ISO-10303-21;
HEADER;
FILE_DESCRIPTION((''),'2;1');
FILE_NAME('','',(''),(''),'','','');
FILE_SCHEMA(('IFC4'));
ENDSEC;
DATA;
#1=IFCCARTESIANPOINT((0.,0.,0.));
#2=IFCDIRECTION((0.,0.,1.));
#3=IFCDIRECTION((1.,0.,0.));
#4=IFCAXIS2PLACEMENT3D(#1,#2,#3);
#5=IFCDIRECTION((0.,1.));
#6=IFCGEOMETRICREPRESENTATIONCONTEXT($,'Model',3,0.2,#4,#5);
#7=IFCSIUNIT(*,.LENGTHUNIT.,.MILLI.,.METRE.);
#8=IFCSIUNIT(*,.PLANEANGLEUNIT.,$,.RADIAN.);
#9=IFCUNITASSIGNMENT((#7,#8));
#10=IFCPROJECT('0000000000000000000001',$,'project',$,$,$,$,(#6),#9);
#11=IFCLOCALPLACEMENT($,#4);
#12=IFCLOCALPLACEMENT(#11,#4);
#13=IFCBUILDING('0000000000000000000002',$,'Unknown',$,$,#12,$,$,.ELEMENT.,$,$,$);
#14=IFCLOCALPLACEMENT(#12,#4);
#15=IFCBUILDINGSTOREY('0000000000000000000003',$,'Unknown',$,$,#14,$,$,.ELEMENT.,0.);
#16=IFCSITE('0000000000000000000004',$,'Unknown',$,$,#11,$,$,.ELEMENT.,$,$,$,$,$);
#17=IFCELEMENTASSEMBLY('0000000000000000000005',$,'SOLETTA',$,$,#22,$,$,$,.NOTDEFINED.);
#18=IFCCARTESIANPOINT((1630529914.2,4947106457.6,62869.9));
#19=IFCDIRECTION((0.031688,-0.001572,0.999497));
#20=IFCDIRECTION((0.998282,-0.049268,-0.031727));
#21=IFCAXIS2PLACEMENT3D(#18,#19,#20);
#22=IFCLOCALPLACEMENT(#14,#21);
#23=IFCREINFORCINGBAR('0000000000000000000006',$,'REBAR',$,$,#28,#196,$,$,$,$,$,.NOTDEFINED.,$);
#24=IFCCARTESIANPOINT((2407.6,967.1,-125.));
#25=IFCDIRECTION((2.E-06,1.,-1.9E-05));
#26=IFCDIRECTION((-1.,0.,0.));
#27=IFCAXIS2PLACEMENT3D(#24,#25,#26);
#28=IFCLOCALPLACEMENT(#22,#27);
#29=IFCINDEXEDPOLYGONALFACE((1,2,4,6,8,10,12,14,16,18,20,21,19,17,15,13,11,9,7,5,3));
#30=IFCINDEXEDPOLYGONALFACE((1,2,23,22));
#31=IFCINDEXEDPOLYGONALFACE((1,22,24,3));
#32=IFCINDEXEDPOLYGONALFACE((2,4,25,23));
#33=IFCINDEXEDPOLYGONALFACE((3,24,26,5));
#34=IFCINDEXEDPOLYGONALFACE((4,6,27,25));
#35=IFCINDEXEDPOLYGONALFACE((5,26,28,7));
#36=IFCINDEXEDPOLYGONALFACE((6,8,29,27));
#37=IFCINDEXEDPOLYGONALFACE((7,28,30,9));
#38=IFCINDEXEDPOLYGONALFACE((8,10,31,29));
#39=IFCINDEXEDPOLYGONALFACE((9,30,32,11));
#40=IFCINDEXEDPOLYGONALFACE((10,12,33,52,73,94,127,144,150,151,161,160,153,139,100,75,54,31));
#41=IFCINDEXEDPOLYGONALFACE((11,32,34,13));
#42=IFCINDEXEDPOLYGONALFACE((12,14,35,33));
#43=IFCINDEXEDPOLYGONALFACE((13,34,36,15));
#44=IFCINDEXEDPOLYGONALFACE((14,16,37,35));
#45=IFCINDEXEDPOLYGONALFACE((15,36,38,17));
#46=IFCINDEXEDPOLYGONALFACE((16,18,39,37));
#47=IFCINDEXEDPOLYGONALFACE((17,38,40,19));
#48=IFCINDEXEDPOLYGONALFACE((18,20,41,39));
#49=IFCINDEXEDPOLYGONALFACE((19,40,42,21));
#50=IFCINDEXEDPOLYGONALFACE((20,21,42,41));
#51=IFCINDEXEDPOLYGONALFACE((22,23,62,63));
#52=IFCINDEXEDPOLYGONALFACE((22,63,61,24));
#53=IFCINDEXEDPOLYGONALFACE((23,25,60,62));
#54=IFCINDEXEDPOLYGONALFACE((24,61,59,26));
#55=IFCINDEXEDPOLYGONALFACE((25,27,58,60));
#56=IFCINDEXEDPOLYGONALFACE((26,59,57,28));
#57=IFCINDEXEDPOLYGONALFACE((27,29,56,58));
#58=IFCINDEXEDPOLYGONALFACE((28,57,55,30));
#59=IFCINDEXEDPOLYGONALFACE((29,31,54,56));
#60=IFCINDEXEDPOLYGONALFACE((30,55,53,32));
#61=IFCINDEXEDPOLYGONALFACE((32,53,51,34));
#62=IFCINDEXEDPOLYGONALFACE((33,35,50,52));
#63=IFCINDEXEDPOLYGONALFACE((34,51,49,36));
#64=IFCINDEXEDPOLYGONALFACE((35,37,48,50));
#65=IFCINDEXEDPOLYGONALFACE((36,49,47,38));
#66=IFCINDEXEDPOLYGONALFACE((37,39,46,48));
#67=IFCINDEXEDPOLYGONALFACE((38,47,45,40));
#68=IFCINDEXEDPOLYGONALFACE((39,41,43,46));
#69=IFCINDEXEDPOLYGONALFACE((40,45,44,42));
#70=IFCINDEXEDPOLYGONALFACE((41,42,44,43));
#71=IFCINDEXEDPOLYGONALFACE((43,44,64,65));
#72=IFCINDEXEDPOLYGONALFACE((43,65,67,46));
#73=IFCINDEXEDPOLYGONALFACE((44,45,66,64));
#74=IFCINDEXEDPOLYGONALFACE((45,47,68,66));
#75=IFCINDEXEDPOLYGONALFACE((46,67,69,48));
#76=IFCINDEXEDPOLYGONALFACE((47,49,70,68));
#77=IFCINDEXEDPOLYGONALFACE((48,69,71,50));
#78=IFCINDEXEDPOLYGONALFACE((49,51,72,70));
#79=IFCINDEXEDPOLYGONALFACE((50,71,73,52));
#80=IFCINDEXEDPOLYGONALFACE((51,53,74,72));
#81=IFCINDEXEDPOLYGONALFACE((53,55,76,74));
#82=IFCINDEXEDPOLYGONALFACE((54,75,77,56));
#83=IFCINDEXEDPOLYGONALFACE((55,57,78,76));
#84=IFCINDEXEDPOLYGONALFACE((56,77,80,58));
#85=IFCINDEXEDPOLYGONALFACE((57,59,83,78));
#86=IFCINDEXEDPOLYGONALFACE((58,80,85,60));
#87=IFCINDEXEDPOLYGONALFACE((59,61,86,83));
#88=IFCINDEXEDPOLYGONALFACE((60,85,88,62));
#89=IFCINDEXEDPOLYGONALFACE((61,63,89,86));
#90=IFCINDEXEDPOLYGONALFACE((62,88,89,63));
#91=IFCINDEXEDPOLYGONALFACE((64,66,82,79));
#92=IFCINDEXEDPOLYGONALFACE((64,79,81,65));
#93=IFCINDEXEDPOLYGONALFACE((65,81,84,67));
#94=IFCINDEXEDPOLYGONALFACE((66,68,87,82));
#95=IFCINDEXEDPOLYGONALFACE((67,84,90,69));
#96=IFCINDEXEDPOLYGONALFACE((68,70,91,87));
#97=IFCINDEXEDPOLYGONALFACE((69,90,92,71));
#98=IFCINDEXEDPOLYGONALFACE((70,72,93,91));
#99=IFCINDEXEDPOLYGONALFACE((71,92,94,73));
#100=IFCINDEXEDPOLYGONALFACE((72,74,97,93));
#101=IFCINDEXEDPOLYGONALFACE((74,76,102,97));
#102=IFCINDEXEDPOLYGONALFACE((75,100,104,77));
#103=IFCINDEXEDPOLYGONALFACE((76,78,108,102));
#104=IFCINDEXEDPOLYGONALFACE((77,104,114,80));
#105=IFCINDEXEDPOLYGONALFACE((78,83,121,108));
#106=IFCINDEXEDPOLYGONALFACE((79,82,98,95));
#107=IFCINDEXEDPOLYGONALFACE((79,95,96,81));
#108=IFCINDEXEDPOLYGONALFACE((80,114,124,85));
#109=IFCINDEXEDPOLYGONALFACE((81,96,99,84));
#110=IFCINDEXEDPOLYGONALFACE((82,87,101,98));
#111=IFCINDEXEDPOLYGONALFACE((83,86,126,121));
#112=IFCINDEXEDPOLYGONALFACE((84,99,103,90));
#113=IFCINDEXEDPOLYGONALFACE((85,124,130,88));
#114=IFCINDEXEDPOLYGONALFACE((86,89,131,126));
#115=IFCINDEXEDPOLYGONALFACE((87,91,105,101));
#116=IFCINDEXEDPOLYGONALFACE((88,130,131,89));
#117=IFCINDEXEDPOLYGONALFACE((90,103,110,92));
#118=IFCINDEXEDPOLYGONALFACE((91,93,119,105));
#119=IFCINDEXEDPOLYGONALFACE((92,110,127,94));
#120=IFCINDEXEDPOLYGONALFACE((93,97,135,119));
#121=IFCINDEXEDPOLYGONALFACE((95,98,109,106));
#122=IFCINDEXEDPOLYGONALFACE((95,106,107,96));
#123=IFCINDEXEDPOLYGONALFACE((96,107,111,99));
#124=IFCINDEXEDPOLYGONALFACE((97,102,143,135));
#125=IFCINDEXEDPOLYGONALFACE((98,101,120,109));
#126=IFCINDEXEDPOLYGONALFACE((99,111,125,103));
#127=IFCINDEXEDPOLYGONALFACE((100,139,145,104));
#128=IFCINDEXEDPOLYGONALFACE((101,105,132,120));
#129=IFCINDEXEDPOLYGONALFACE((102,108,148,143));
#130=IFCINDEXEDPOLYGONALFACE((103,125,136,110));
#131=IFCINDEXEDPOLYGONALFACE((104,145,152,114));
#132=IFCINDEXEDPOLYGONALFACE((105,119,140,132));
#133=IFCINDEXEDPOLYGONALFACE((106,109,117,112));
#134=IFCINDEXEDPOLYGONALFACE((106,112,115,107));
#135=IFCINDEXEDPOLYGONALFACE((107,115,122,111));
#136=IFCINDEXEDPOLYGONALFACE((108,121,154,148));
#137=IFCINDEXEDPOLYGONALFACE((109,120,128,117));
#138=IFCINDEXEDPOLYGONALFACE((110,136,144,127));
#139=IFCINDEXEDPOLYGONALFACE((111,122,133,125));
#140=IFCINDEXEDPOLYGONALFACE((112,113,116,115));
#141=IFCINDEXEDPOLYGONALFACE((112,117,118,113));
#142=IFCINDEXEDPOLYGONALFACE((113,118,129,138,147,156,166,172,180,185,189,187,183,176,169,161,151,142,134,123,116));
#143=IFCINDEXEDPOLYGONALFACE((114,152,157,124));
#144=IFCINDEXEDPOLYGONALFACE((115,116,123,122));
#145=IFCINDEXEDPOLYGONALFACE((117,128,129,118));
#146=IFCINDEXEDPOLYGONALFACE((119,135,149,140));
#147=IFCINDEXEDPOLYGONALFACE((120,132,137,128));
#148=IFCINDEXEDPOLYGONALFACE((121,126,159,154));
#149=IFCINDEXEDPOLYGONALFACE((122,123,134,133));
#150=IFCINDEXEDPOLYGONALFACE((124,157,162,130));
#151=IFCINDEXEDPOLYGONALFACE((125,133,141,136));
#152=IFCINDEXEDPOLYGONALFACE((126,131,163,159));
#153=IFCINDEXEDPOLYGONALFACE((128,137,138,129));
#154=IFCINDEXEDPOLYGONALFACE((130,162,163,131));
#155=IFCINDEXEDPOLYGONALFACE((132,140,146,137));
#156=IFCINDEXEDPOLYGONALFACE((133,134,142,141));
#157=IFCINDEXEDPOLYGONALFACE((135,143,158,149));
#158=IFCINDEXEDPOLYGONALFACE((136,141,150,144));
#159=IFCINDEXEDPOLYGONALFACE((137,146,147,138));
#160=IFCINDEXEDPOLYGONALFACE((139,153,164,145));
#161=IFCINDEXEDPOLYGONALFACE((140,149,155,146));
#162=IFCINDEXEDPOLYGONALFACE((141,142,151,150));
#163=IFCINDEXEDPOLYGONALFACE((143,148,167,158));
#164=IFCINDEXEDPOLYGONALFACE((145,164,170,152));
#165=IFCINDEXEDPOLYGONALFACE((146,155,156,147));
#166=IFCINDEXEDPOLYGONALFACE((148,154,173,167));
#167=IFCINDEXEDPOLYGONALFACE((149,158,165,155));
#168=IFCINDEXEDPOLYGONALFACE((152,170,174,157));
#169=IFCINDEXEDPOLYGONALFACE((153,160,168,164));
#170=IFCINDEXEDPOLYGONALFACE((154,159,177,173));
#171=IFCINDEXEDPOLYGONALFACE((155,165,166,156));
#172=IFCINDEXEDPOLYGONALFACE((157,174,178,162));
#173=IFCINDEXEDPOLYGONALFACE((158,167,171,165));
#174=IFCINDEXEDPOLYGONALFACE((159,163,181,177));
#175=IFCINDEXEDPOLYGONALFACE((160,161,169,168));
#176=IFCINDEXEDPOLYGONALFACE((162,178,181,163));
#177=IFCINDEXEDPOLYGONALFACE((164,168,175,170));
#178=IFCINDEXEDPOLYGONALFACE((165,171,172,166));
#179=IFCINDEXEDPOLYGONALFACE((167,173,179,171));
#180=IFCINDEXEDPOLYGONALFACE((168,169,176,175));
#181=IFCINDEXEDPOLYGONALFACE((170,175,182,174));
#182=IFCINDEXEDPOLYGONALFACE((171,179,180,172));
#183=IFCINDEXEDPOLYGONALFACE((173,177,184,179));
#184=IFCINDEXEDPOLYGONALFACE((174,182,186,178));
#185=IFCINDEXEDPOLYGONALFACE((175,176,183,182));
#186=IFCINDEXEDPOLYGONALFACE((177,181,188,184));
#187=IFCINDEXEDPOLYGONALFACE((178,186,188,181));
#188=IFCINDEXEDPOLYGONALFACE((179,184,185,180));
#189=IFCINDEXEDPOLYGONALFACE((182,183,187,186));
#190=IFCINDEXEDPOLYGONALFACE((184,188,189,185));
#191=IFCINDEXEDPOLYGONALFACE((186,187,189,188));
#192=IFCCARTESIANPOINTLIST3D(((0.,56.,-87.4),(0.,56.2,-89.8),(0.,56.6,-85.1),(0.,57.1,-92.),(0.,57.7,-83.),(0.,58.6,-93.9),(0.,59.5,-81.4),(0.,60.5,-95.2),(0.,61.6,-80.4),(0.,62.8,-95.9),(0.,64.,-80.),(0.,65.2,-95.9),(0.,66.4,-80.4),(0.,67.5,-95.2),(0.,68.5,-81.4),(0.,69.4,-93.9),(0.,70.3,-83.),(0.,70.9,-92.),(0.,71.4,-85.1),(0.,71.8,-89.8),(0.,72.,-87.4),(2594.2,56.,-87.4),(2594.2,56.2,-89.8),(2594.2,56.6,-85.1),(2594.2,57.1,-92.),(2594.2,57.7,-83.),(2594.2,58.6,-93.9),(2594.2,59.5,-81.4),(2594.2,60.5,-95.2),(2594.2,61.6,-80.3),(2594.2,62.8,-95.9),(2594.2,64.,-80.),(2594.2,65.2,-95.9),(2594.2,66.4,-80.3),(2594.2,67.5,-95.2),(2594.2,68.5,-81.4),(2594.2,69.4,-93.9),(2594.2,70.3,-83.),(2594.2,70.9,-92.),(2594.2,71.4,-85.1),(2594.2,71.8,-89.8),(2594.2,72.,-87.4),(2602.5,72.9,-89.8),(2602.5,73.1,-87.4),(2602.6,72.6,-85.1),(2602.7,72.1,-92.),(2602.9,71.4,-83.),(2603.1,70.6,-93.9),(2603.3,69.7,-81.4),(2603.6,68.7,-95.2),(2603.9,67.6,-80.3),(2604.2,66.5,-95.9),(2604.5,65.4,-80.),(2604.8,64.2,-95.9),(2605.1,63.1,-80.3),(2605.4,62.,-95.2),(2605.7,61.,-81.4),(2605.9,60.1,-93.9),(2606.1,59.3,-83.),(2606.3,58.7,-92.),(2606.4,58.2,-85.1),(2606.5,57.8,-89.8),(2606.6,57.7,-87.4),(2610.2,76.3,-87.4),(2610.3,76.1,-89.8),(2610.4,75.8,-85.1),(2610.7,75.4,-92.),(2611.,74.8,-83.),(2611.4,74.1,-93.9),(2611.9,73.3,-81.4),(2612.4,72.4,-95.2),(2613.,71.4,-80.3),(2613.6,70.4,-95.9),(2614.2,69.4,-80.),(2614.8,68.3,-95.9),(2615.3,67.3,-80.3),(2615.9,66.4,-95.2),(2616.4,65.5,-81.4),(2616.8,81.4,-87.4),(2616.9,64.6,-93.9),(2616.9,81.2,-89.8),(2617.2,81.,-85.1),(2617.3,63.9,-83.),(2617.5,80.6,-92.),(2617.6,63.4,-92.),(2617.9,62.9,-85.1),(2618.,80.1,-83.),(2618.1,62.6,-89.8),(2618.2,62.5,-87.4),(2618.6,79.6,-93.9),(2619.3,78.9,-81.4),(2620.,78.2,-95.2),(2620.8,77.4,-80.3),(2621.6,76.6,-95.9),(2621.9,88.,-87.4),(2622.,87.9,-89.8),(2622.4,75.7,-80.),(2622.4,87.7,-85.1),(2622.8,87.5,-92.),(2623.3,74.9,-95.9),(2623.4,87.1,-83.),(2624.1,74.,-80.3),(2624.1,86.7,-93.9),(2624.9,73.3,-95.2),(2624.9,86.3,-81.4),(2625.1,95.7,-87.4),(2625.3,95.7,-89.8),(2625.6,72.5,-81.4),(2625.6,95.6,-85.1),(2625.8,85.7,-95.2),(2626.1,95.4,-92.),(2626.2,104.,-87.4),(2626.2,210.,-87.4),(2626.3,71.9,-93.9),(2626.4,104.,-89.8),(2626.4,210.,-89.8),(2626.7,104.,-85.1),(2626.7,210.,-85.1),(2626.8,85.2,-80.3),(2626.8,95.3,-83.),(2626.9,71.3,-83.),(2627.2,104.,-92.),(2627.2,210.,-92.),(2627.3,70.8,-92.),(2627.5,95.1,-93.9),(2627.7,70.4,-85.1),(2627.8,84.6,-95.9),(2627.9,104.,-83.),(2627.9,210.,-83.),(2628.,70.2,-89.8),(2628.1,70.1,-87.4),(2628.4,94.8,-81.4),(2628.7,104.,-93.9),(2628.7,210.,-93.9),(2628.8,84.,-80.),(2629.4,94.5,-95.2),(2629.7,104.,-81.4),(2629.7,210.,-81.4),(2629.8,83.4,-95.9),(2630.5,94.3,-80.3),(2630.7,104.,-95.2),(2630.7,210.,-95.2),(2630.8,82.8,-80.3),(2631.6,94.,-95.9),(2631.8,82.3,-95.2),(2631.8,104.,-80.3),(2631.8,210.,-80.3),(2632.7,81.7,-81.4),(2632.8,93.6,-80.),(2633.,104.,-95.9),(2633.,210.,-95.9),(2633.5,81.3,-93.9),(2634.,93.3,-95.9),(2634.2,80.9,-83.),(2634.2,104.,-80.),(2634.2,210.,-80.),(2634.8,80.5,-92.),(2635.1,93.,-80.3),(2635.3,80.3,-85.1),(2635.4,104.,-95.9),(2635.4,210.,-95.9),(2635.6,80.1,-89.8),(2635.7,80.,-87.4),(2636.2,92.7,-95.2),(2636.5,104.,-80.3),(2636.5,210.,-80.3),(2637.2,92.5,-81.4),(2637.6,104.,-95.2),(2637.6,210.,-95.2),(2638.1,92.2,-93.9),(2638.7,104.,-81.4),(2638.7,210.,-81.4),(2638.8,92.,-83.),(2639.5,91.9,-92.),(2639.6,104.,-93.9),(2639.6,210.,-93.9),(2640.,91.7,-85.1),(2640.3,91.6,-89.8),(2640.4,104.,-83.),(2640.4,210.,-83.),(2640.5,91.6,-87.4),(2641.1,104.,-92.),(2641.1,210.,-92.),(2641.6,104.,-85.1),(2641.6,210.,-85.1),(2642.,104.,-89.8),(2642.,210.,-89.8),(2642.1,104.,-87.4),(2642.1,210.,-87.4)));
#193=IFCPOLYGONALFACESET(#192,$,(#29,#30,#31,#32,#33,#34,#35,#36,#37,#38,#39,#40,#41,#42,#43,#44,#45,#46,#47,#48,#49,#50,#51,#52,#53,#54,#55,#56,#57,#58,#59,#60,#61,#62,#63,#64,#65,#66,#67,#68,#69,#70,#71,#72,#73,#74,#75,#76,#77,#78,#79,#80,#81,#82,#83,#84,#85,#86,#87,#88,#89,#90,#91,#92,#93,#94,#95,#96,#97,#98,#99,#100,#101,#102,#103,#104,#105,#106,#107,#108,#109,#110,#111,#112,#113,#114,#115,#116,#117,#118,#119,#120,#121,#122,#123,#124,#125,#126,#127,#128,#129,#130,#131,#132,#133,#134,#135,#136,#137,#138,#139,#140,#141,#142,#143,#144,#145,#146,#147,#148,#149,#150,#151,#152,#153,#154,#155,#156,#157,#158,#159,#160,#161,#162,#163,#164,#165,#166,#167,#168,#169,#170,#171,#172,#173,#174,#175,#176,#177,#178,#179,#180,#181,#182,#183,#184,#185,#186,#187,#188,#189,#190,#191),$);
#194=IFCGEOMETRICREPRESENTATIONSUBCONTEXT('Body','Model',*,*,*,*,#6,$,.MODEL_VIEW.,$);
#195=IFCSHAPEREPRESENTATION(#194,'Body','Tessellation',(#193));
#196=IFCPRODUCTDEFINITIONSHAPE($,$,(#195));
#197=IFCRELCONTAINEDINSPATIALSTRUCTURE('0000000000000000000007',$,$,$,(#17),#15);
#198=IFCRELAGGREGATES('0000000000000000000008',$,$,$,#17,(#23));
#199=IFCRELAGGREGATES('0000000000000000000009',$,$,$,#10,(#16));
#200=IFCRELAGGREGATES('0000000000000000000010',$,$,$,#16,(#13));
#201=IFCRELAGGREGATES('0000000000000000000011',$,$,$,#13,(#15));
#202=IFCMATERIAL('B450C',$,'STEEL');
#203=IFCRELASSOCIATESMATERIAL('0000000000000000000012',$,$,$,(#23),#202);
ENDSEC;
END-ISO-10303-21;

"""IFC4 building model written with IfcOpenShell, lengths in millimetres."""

from ifc_helpers import new_model, entity, si_unit, direction, frame, origin_with_axes, place, context, subcontext, project, spatial, material, element, aggregate, save


model = new_model("IFC4")

# Units and contexts
model_context = context("Model", 3, precision=0.2, world=origin_with_axes(), true_north=direction((0.0, 1.0)))
body_context = subcontext(model_context, "Body", "Model", "MODEL_VIEW")
ifc_project = project(units=[si_unit("LENGTHUNIT", "METRE", prefix="MILLI"), si_unit("PLANEANGLEUNIT", "RADIAN")], contexts=[model_context])

# Site, building, storey
site_placement = place(None, origin_with_axes())
site = spatial("IfcSite", under=ifc_project, at=site_placement, Name="Unknown", CompositionType="ELEMENT")
building_placement = place(site_placement, origin_with_axes())
building = spatial("IfcBuilding", under=site, at=building_placement, Name="Unknown", CompositionType="ELEMENT")
storey_placement = place(building_placement, origin_with_axes())
storey = spatial("IfcBuildingStorey", under=building, at=storey_placement, Name="Unknown", CompositionType="ELEMENT", Elevation=0.0)

# Element assembly
ifc_material = material(Name="B450C", Category="STEEL")
assembly_1_placement = place(storey_placement, frame((1630529914.2, 4947106457.6, 62869.9), z_axis=(0.031688, -0.001572, 0.999497), x_axis=(0.998282, -0.049268, -0.031727)))
assembly_1 = element("IfcElementAssembly", 1, at=assembly_1_placement, inside=storey, Name="SOLETTA", PredefinedType="NOTDEFINED")

# Reinforcing bar
reinforcing_bar_1_placement = place(assembly_1_placement, frame((2407.6, 967.1, -125.0), z_axis=(0.000002, 1.0, -0.000019), x_axis=(-1.0, 0.0, 0.0)))
reinforcing_bar_1 = element("IfcReinforcingBar", 2, at=reinforcing_bar_1_placement, material=ifc_material, Name="REBAR", PredefinedType="NOTDEFINED", context=body_context, shape_type="AdvancedSweptSolid", body=[
    entity("IfcSweptDiskSolid", entity("IfcIndexedPolyCurve", entity("IfcCartesianPointList3D", [[0.0, 64.0, -88.0], [2594.2, 64.0, -88.0], [2622.4, 75.7, -88.0], [2634.2, 104.0, -88.0], [2634.2, 210.0, -88.0]]), [entity("IfcLineIndex", [1, 2]), entity("IfcArcIndex", [2, 3, 4]), entity("IfcLineIndex", [4, 5])]), 8.0),
])
aggregate(assembly_1, [reinforcing_bar_1])

save(model, "model.ifc")
